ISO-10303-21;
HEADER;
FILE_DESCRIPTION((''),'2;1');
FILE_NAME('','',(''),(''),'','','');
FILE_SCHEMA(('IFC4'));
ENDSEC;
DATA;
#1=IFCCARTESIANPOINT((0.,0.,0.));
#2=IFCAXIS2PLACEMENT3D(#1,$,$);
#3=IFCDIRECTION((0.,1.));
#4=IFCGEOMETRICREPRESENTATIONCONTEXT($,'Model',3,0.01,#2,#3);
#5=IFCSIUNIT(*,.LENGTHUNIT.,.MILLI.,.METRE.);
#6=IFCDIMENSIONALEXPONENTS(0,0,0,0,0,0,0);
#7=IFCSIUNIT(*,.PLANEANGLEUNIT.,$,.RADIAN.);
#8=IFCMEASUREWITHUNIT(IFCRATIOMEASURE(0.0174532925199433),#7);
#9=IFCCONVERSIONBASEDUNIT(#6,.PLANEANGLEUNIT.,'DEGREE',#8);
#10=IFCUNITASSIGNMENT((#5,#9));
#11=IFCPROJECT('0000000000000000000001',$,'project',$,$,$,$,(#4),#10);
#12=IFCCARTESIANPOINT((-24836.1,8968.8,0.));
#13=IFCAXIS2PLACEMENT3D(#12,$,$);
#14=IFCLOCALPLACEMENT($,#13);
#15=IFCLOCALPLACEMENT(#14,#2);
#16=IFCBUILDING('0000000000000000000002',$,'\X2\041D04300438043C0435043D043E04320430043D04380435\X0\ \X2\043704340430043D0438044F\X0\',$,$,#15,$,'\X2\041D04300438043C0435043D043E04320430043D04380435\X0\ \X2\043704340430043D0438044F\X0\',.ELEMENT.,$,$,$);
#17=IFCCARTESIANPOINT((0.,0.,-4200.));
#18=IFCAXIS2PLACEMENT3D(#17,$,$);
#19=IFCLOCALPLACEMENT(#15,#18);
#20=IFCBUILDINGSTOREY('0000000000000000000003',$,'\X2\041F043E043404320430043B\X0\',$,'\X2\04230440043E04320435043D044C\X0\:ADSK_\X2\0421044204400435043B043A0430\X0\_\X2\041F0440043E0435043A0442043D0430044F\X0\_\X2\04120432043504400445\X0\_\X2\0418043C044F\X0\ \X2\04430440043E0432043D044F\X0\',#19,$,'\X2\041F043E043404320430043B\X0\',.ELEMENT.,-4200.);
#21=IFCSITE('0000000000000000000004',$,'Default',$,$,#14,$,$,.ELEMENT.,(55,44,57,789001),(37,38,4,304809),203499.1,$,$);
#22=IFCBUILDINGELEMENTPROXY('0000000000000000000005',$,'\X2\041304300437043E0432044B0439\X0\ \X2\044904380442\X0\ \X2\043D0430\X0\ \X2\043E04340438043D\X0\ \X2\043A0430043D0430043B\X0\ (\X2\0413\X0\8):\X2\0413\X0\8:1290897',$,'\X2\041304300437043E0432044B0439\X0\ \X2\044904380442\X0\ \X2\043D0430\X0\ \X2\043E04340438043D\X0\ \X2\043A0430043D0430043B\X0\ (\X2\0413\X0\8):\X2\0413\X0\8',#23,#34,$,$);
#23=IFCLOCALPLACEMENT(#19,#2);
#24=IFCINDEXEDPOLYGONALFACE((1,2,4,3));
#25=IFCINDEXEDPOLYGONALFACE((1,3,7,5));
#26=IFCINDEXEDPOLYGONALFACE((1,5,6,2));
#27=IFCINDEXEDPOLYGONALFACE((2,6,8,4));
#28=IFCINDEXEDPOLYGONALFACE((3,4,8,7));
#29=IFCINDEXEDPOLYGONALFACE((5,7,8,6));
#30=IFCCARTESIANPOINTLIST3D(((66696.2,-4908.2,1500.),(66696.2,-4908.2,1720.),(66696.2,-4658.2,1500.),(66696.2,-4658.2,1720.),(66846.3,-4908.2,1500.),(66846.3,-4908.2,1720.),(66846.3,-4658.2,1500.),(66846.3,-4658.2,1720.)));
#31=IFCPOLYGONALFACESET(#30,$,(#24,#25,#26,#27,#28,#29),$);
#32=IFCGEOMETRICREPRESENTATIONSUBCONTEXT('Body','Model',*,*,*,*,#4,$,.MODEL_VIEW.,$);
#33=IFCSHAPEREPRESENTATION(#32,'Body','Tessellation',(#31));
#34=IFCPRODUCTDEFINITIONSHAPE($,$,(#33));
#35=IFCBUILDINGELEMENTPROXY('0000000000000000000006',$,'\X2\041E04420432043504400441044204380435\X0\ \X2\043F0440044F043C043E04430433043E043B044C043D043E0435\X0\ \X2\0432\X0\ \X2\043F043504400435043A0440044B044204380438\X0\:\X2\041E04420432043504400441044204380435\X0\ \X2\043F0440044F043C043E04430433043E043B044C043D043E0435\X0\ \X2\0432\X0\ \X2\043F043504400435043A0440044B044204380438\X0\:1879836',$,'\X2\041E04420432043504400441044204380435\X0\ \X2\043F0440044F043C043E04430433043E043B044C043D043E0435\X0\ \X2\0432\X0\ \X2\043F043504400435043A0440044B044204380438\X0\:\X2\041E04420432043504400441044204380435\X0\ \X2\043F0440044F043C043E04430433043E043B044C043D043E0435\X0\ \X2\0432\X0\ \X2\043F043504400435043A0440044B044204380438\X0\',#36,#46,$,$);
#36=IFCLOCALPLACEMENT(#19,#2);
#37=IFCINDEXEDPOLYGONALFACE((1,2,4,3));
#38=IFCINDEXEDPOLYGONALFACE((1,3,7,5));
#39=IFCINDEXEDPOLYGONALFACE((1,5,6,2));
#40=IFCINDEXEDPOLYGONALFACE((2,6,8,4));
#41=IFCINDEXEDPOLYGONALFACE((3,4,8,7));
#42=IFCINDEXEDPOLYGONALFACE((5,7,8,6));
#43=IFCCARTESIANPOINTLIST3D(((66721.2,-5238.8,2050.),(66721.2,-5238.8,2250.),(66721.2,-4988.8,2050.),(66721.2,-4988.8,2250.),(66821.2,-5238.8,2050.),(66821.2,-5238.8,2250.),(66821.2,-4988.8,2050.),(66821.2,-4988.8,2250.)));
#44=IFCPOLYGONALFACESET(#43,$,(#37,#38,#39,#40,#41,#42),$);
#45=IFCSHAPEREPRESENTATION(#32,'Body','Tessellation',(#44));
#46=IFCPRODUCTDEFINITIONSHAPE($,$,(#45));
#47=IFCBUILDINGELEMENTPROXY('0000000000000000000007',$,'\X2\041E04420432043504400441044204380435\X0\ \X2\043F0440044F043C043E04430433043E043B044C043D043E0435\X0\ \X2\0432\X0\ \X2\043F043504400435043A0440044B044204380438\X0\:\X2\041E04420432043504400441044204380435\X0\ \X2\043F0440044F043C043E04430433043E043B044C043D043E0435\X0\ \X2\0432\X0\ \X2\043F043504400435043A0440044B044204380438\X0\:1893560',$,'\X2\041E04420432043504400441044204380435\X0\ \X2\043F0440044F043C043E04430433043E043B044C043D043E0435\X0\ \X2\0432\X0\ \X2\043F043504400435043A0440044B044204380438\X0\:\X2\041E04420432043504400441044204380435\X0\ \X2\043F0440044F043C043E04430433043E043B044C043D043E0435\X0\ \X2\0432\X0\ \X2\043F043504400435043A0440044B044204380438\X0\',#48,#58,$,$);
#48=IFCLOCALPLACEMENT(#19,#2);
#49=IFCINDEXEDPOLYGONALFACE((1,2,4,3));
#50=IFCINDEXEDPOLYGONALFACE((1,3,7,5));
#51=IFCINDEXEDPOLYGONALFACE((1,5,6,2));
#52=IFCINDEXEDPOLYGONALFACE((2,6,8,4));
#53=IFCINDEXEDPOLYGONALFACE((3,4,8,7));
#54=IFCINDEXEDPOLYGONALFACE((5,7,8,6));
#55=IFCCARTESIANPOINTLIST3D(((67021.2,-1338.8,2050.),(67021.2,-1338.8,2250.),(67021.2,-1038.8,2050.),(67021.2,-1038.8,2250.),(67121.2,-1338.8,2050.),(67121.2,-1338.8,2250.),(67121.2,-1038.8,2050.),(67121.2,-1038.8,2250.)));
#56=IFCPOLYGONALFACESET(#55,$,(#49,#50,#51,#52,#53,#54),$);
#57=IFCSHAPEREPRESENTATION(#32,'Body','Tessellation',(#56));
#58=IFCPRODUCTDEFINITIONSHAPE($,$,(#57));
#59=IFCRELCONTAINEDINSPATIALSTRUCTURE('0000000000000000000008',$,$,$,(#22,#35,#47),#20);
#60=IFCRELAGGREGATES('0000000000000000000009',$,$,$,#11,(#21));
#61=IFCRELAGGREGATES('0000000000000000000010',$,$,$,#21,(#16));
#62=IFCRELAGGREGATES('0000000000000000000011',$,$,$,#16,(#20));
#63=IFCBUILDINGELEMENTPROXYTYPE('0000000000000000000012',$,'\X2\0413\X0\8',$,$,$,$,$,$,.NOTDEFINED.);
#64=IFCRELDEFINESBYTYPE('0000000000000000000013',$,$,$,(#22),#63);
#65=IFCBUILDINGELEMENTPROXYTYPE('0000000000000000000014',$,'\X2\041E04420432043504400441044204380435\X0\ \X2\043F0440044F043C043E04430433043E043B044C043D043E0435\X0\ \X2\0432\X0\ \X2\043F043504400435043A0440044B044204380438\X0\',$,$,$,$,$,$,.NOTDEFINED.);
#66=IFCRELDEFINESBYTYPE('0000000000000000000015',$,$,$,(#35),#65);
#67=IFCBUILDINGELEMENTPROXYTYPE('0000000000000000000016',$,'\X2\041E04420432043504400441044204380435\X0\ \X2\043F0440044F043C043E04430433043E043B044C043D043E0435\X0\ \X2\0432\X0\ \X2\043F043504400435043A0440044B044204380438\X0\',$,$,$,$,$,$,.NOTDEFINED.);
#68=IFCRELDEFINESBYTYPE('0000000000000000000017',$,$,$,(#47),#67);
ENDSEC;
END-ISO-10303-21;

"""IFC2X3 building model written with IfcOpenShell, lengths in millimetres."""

from ifc_helpers import new_model, entity, si_unit, converted_unit, direction, frame, origin, origin_2d_with_axis, place, context, subcontext, project, spatial, rectangle, extrude, type_object, element, save


model = new_model("IFC2X3")

# Units and contexts
model_context = context("Model", 3, precision=0.01, world=origin(), true_north=direction((0.0, 1.0)))
body_context = subcontext(model_context, "Body", "Model", "MODEL_VIEW")
ifc_project = project(units=[si_unit("LENGTHUNIT", "METRE", prefix="MILLI"), converted_unit("PLANEANGLEUNIT", "DEGREE", entity("IfcRatioMeasure", 0.0174532925199433), si_unit("PLANEANGLEUNIT", "RADIAN"), dimensions=[0, 0, 0, 0, 0, 0, 0])], contexts=[model_context])

# Site, building, storey
site_placement = place(None, frame((-24836.1, 8968.8, 0.0)))
site = spatial("IfcSite", under=ifc_project, at=site_placement, Name="Default", CompositionType="ELEMENT", RefLatitude=(55, 44, 57, 789001), RefLongitude=(37, 38, 4, 304809), RefElevation=203499.1)
building_placement = place(site_placement, origin())
building = spatial("IfcBuilding", under=site, at=building_placement, Name="Наименование здания", LongName="Наименование здания", CompositionType="ELEMENT")
storey_placement = place(building_placement, frame((0.0, 0.0, -4200.0)))
storey = spatial("IfcBuildingStorey", under=building, at=storey_placement, Name="Подвал", ObjectType="Уровень:ADSK_Стрелка_Проектная_Вверх_Имя уровня", LongName="Подвал", CompositionType="ELEMENT", Elevation=-4200.0)

# Building element proxies
building_element_proxy_type_1 = type_object("IfcBuildingElementProxyType", Name="Г8", PredefinedType="NOTDEFINED")
proxy_1_placement = place(storey_placement, frame((66696.2, -4908.1, 1500.0)))
element("IfcBuildingElementProxy", 1, at=proxy_1_placement, inside=storey, type_object=building_element_proxy_type_1, Name="Газовый щит на один канал (Г8):Г8:1290897", ObjectType="Газовый щит на один канал (Г8):Г8", context=body_context, shape_type="SweptSolid", body=[
    extrude(rectangle(XDim=250.0, YDim=150.0, at=origin_2d_with_axis()), frame((75.0, 125.0, 0.0), z_axis=(0.0, 0.0, 1.0), x_axis=(0.0, 1.0, 0.0)), (0.0, 0.0, 1.0), 220.0),
])
building_element_proxy_type_2 = type_object("IfcBuildingElementProxyType", Name="Отверстие прямоугольное в перекрытии", PredefinedType="NOTDEFINED")
proxy_2_placement = place(storey_placement, frame((66721.2, -5238.8, 2050.0)))
element("IfcBuildingElementProxy", 2, at=proxy_2_placement, inside=storey, type_object=building_element_proxy_type_2, Name="Отверстие прямоугольное в перекрытии:Отверстие прямоугольное в перекрытии:1879836", ObjectType="Отверстие прямоугольное в перекрытии:Отверстие прямоугольное в перекрытии", context=body_context, shape_type="SweptSolid", body=[
    extrude(rectangle(XDim=250.0, YDim=100.0, at=origin_2d_with_axis()), frame((50.0, 125.0, 0.0), z_axis=(0.0, 0.0, 1.0), x_axis=(0.0, -1.0, 0.0)), (0.0, 0.0, 1.0), 200.0),
])
building_element_proxy_type_3 = type_object("IfcBuildingElementProxyType", Name="Отверстие прямоугольное в перекрытии", PredefinedType="NOTDEFINED")
proxy_3_placement = place(storey_placement, frame((67021.2, -1338.8, 2050.0)))
element("IfcBuildingElementProxy", 3, at=proxy_3_placement, inside=storey, type_object=building_element_proxy_type_3, Name="Отверстие прямоугольное в перекрытии:Отверстие прямоугольное в перекрытии:1893560", ObjectType="Отверстие прямоугольное в перекрытии:Отверстие прямоугольное в перекрытии", context=body_context, shape_type="SweptSolid", body=[
    extrude(rectangle(XDim=300.0, YDim=100.0, at=origin_2d_with_axis()), frame((50.0, 150.0, 0.0), z_axis=(0.0, 0.0, 1.0), x_axis=(0.0, 1.0, 0.0)), (0.0, 0.0, 1.0), 200.0),
])

save(model, "model.ifc")
